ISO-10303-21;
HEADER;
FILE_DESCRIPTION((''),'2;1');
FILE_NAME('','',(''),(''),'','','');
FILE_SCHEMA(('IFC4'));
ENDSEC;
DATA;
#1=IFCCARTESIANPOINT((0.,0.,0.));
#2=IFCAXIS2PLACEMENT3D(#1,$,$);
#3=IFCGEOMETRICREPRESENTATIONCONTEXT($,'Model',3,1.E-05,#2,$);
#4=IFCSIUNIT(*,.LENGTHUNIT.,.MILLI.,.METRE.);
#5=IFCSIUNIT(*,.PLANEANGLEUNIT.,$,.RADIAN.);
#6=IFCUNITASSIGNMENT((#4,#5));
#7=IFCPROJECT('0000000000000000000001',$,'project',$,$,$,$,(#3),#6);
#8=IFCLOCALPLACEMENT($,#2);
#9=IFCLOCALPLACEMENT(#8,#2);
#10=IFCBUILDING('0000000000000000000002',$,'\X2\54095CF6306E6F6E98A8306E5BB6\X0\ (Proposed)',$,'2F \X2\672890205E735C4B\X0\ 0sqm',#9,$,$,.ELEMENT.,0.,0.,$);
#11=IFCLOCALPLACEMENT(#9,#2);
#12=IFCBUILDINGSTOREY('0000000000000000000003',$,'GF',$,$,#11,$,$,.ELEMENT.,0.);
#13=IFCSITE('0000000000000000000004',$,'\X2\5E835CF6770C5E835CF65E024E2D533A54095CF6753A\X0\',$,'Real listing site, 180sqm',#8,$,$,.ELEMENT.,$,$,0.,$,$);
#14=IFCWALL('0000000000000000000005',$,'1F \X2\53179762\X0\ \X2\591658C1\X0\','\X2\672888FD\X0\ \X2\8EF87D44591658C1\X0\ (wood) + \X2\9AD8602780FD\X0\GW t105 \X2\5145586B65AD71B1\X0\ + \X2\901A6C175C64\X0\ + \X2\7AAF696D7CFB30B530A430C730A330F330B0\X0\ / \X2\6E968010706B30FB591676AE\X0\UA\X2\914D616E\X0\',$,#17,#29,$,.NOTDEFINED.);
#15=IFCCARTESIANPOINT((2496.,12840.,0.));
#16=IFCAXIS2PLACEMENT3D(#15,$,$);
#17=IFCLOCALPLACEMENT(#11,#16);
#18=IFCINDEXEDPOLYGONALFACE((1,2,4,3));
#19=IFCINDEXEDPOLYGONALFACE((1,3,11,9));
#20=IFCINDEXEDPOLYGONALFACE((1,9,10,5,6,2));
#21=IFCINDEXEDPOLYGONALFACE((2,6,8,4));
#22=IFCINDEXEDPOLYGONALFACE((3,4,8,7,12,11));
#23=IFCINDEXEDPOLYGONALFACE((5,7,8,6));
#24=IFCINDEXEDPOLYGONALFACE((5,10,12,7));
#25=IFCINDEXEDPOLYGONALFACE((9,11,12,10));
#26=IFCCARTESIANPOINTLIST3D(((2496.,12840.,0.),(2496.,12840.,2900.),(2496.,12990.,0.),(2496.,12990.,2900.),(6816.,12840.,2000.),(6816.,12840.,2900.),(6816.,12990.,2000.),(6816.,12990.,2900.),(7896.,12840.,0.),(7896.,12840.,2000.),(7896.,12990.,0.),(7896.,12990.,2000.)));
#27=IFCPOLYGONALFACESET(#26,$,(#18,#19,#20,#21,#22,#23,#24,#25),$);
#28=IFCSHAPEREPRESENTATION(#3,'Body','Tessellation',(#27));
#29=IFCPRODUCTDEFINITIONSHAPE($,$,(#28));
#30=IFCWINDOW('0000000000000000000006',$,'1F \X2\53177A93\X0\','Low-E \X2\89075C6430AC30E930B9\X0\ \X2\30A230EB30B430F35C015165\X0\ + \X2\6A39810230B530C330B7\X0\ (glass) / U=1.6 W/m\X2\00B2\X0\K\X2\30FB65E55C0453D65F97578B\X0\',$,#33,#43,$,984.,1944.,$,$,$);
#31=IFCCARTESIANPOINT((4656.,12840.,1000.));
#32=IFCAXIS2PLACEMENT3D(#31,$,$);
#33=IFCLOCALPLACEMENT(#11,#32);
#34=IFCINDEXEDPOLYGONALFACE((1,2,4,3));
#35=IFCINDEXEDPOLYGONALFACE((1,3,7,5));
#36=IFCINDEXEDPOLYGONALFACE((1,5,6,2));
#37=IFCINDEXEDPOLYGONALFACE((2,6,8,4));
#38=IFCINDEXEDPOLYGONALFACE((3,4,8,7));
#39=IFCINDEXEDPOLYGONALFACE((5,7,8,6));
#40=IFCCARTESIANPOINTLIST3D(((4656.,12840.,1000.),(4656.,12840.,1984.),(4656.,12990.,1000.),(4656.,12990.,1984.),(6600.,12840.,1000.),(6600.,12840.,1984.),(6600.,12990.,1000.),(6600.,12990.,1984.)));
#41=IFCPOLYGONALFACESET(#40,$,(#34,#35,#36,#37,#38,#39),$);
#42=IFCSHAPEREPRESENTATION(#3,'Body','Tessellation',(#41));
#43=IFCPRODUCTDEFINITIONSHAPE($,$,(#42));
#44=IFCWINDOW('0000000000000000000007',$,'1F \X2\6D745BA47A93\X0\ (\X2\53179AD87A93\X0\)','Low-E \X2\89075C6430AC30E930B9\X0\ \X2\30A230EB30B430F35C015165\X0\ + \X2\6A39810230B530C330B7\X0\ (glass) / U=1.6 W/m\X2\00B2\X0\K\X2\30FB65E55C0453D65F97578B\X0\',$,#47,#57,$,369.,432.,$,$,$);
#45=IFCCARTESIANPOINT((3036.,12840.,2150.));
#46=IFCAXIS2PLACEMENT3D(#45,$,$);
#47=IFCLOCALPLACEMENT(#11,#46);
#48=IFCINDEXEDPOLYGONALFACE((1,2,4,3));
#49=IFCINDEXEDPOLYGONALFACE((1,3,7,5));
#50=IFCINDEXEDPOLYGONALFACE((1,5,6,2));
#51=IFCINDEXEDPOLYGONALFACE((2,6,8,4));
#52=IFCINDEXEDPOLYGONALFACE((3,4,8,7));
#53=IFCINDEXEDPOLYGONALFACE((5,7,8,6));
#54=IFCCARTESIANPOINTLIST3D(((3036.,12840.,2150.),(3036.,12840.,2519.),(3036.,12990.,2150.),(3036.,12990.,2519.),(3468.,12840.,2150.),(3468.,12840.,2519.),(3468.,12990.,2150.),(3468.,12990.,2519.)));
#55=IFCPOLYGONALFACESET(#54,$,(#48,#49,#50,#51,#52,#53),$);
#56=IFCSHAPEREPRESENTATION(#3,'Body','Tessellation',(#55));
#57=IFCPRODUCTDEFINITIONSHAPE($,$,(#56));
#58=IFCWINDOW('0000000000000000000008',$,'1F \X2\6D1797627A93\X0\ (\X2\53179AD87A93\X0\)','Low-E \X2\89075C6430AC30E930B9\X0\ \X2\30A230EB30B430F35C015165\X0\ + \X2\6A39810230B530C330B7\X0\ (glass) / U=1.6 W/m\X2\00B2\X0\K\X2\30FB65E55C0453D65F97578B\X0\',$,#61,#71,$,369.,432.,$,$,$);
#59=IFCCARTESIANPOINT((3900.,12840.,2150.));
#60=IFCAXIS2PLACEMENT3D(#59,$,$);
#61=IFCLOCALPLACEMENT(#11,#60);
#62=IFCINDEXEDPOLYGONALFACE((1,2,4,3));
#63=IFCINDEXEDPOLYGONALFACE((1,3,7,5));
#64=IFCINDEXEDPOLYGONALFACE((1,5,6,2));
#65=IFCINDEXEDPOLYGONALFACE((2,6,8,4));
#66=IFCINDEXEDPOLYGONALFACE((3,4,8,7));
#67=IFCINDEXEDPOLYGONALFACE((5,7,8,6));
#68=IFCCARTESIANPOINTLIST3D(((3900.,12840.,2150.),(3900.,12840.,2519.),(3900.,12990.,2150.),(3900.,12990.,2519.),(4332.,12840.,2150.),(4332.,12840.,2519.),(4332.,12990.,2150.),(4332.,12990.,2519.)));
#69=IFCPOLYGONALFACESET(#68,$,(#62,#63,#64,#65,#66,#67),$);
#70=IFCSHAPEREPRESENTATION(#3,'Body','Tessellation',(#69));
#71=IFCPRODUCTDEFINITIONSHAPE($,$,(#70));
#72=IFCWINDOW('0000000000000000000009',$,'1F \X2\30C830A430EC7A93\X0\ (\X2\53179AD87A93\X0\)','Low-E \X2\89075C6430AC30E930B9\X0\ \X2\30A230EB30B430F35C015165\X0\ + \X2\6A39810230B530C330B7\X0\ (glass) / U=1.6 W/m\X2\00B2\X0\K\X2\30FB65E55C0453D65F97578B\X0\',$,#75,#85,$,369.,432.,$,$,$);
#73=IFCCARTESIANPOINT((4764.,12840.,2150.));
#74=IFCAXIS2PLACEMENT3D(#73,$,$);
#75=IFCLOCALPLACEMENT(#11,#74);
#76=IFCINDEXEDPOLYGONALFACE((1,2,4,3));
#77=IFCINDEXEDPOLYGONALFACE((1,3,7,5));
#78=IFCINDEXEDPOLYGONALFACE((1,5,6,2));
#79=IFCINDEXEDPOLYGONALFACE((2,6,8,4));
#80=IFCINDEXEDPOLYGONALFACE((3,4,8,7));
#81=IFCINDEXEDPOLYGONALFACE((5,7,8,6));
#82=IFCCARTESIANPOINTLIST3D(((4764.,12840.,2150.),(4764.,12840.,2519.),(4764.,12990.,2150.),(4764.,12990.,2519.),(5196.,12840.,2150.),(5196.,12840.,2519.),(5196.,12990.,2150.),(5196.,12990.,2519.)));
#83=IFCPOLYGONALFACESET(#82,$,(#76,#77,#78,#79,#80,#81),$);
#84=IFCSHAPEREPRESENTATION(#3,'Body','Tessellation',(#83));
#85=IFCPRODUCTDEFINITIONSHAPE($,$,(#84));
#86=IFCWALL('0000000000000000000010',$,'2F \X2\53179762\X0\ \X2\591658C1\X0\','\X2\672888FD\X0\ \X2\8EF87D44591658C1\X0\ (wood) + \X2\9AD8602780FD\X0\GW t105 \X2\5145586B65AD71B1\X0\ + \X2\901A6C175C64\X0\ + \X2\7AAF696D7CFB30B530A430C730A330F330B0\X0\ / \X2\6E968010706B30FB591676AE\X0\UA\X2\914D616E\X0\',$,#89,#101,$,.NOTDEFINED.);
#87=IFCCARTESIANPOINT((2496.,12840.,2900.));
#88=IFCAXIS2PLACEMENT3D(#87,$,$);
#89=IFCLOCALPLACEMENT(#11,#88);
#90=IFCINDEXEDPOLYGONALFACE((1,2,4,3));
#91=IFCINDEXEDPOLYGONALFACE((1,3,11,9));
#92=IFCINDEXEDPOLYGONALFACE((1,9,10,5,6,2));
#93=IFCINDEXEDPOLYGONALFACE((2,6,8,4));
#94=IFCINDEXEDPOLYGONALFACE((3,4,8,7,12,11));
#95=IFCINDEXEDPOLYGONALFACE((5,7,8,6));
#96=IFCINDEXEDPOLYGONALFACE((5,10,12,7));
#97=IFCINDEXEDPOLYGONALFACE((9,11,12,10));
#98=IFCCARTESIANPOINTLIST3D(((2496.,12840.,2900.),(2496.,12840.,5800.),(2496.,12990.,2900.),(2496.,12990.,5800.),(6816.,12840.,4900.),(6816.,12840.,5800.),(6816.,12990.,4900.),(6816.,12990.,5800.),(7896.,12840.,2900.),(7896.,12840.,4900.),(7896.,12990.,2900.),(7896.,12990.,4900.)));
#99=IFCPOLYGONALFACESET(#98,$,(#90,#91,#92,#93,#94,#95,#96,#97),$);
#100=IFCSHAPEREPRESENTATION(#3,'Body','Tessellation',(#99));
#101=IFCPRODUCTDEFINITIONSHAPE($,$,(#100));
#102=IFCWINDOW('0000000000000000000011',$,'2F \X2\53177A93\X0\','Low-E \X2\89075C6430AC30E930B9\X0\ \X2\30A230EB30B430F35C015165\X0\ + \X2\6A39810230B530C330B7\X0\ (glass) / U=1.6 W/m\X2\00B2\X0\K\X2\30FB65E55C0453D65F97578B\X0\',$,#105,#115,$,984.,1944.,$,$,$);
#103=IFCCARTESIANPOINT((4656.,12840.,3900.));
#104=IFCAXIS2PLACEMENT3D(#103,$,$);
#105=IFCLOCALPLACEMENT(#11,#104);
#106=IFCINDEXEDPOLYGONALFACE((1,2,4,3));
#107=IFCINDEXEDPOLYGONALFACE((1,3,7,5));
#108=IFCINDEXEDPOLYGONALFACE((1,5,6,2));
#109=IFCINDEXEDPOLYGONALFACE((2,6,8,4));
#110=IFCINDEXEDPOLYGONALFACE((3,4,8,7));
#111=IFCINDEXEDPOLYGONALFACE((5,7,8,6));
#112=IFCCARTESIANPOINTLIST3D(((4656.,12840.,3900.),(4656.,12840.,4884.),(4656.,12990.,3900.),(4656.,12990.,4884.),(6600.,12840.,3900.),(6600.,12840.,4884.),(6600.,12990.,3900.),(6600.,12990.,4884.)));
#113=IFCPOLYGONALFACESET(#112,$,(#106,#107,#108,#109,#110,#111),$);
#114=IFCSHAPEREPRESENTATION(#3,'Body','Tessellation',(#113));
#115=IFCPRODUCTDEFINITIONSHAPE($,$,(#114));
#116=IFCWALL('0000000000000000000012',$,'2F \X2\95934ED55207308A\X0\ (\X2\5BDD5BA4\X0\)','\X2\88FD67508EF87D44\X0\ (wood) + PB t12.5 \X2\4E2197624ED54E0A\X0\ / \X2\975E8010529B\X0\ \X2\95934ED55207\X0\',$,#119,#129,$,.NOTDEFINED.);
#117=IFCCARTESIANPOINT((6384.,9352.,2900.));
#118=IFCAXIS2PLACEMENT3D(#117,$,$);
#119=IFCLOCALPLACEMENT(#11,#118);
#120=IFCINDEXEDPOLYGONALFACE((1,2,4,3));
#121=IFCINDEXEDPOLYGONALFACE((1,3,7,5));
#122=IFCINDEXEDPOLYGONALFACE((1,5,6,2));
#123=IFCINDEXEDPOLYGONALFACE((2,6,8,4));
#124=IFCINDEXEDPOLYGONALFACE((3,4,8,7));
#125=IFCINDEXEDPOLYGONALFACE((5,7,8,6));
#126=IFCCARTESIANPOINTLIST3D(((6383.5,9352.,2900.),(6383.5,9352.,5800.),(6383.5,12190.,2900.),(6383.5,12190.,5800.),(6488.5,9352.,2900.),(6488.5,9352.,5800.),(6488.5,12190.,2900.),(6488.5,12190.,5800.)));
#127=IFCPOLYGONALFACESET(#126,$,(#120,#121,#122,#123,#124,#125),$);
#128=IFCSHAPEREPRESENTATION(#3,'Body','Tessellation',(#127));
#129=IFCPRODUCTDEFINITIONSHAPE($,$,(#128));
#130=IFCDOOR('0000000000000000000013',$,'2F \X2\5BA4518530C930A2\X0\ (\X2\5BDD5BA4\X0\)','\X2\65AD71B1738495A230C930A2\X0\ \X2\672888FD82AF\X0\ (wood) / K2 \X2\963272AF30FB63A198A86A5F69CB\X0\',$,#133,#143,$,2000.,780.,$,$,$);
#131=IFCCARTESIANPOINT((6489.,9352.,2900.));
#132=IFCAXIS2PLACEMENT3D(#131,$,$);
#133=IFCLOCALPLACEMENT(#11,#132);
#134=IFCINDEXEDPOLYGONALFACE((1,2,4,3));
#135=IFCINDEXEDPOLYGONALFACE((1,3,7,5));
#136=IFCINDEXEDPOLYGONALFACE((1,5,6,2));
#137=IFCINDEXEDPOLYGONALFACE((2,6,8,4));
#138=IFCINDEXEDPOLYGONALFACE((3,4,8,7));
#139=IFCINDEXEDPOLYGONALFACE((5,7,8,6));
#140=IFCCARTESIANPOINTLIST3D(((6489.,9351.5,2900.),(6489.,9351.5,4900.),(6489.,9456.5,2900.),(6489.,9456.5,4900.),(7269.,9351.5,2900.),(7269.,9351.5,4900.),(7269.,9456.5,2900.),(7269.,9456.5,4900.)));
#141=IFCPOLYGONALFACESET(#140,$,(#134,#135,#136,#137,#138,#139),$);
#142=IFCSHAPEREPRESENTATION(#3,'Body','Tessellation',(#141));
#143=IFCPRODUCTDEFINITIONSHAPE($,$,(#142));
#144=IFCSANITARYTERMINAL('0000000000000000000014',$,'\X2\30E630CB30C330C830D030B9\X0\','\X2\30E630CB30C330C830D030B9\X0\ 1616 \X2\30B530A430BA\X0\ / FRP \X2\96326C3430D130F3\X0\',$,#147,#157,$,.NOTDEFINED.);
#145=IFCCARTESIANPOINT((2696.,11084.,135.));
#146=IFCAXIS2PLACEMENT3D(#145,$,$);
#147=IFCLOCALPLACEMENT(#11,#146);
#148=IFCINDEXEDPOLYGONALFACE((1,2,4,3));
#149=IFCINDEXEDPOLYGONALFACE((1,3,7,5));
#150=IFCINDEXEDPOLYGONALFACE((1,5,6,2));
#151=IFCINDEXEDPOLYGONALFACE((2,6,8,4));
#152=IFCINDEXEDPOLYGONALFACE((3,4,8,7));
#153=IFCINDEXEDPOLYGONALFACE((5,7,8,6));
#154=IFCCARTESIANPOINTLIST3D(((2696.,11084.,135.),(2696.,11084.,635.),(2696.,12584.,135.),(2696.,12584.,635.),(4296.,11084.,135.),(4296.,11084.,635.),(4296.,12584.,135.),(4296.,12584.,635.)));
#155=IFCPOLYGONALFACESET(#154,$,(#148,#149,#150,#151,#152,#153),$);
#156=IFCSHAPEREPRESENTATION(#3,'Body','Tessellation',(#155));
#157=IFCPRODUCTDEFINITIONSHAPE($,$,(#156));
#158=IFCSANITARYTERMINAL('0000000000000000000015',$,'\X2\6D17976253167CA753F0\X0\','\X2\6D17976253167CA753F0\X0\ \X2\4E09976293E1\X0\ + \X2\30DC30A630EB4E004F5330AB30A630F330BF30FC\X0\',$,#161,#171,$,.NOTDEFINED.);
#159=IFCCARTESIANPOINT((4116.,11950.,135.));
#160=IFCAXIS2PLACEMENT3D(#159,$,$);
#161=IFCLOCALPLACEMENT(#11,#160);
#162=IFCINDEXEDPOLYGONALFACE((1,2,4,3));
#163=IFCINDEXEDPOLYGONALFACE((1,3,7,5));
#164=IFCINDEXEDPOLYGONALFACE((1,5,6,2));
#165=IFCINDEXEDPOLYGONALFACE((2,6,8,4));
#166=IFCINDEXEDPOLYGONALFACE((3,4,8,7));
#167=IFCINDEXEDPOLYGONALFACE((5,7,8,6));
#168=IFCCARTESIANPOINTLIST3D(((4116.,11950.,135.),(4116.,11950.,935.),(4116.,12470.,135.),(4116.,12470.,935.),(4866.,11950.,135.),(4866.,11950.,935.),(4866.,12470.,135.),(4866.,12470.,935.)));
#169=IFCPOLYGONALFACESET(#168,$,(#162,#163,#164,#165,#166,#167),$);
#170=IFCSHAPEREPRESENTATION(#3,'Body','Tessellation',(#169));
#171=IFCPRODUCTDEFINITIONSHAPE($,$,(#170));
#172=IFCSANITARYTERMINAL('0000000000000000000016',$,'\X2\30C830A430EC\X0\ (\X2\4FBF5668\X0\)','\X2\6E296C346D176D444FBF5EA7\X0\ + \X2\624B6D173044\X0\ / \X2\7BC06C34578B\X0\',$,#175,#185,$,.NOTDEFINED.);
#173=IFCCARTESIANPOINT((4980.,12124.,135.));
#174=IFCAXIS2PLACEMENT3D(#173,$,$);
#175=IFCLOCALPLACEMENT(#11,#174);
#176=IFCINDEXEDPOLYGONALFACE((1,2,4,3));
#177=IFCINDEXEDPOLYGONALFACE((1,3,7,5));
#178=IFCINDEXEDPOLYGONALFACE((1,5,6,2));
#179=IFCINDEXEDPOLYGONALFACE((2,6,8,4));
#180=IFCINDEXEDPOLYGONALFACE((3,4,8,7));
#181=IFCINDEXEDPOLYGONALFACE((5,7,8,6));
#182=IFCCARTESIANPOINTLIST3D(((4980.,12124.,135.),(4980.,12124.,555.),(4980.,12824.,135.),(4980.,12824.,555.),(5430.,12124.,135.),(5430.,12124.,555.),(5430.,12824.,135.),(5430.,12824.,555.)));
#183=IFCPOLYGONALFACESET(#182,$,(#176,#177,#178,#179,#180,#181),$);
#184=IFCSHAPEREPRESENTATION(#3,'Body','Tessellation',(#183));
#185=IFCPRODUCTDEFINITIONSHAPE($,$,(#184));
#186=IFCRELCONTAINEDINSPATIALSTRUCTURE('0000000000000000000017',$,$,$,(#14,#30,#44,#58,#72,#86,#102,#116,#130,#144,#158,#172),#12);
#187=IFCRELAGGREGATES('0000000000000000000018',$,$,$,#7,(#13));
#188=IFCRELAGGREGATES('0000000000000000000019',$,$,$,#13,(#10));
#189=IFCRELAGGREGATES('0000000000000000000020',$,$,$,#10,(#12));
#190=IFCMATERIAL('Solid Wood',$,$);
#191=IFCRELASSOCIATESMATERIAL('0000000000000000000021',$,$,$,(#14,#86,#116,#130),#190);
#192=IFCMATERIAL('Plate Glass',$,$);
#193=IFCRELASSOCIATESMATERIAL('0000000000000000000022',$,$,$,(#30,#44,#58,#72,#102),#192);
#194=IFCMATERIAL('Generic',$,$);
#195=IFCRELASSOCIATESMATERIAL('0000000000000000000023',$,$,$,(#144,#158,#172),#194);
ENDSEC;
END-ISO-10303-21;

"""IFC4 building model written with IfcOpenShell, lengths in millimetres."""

from ifc_helpers import new_model, si_unit, frame, frame_2d, origin, place, context, project, spatial, rectangle, extrude, material, element, fill, save


model = new_model("IFC4")

# Units and contexts
model_context = context("Model", 3, precision=1e-05, world=origin())
ifc_project = project(units=[si_unit("LENGTHUNIT", "METRE", prefix="MILLI"), si_unit("PLANEANGLEUNIT", "RADIAN")], contexts=[model_context])

# Site, building, storey
site_placement = place(None, origin())
site = spatial("IfcSite", under=ifc_project, at=site_placement, Name="広島県広島市中区吉島町", ObjectType="Real listing site, 180sqm", CompositionType="ELEMENT", RefElevation=0.0)
building_placement = place(site_placement, origin())
building = spatial("IfcBuilding", under=site, at=building_placement, Name="吉島の潮風の家 (Proposed)", ObjectType="2F 木造平屋 0sqm", CompositionType="ELEMENT", ElevationOfRefHeight=0.0, ElevationOfTerrain=0.0)
storey_placement = place(building_placement, origin())
storey = spatial("IfcBuildingStorey", under=building, at=storey_placement, Name="GF", CompositionType="ELEMENT", Elevation=0.0)

# Wall, openings, windows
ifc_material_1 = material(Name="Solid Wood")
wall_1_placement = place(storey_placement, frame((2496.0, 12840.0, 0.0)))
wall_1 = element("IfcWall", 1, at=wall_1_placement, inside=storey, material=ifc_material_1, Name="1F 北面 外壁", Description="木製 軸組外壁 (wood) + 高性能GW t105 充填断熱 + 通気層 + 窯業系サイディング / 準耐火・外皮UA配慮", PredefinedType="NOTDEFINED", context=model_context, shape_type="SweptSolid", body=[
    extrude(rectangle(XDim=5400.0, YDim=150.0, at=frame_2d((2700.0, 75.0))), frame((2496.0, 12840.0, 0.0)), (0.0, 0.0, 1.0), 2900.0),
])
opening_1_placement = place(storey_placement, frame((4656.0, 12840.0, 1000.0)))
opening_1 = element("IfcOpeningElement", 2, at=opening_1_placement, cuts=wall_1, PredefinedType="NOTDEFINED", context=model_context, shape_type="SweptSolid", body=[
    extrude(rectangle(XDim=1944.0, YDim=150.0, at=frame_2d((972.0, 75.0))), frame((4656.0, 12840.0, 1000.0)), (0.0, 0.0, 1.0), 984.0),
])
opening_2_placement = place(storey_placement, frame((3036.0, 12840.0, 2150.0)))
opening_2 = element("IfcOpeningElement", 3, at=opening_2_placement, cuts=wall_1, PredefinedType="NOTDEFINED", context=model_context, shape_type="SweptSolid", body=[
    extrude(rectangle(XDim=432.0, YDim=150.0, at=frame_2d((216.0, 75.0))), frame((3036.0, 12840.0, 2150.0)), (0.0, 0.0, 1.0), 369.0),
])
opening_3_placement = place(storey_placement, frame((3900.0, 12840.0, 2150.0)))
opening_3 = element("IfcOpeningElement", 4, at=opening_3_placement, cuts=wall_1, PredefinedType="NOTDEFINED", context=model_context, shape_type="SweptSolid", body=[
    extrude(rectangle(XDim=432.0, YDim=150.0, at=frame_2d((216.0, 75.0))), frame((3900.0, 12840.0, 2150.0)), (0.0, 0.0, 1.0), 369.0),
])
opening_4_placement = place(storey_placement, frame((4764.0, 12840.0, 2150.0)))
opening_4 = element("IfcOpeningElement", 5, at=opening_4_placement, cuts=wall_1, PredefinedType="NOTDEFINED", context=model_context, shape_type="SweptSolid", body=[
    extrude(rectangle(XDim=432.0, YDim=150.0, at=frame_2d((216.0, 75.0))), frame((4764.0, 12840.0, 2150.0)), (0.0, 0.0, 1.0), 369.0),
])
ifc_material_2 = material(Name="Plate Glass")
window_1_placement = place(storey_placement, frame((4656.0, 12840.0, 1000.0)))
window_1 = element("IfcWindow", 6, at=window_1_placement, inside=storey, material=ifc_material_2, Name="1F 北窓", Description="Low-E 複層ガラス アルゴン封入 + 樹脂サッシ (glass) / U=1.6 W/m²K・日射取得型", OverallHeight=984.0, OverallWidth=1944.0, context=model_context, shape_type="SweptSolid", body=[
    extrude(rectangle(XDim=1944.0, YDim=150.0, at=frame_2d((972.0, 75.0))), frame((4656.0, 12840.0, 1000.0)), (0.0, 0.0, 1.0), 984.0),
])
fill(opening_1, window_1)
window_2_placement = place(storey_placement, frame((3036.0, 12840.0, 2150.0)))
window_2 = element("IfcWindow", 7, at=window_2_placement, inside=storey, material=ifc_material_2, Name="1F 浴室窓 (北高窓)", Description="Low-E 複層ガラス アルゴン封入 + 樹脂サッシ (glass) / U=1.6 W/m²K・日射取得型", OverallHeight=369.0, OverallWidth=432.0, context=model_context, shape_type="SweptSolid", body=[
    extrude(rectangle(XDim=432.0, YDim=150.0, at=frame_2d((216.0, 75.0))), frame((3036.0, 12840.0, 2150.0)), (0.0, 0.0, 1.0), 369.0),
])
fill(opening_2, window_2)
window_3_placement = place(storey_placement, frame((3900.0, 12840.0, 2150.0)))
window_3 = element("IfcWindow", 8, at=window_3_placement, inside=storey, material=ifc_material_2, Name="1F 洗面窓 (北高窓)", Description="Low-E 複層ガラス アルゴン封入 + 樹脂サッシ (glass) / U=1.6 W/m²K・日射取得型", OverallHeight=369.0, OverallWidth=432.0, context=model_context, shape_type="SweptSolid", body=[
    extrude(rectangle(XDim=432.0, YDim=150.0, at=frame_2d((216.0, 75.0))), frame((3900.0, 12840.0, 2150.0)), (0.0, 0.0, 1.0), 369.0),
])
fill(opening_3, window_3)
window_4_placement = place(storey_placement, frame((4764.0, 12840.0, 2150.0)))
window_4 = element("IfcWindow", 9, at=window_4_placement, inside=storey, material=ifc_material_2, Name="1F トイレ窓 (北高窓)", Description="Low-E 複層ガラス アルゴン封入 + 樹脂サッシ (glass) / U=1.6 W/m²K・日射取得型", OverallHeight=369.0, OverallWidth=432.0, context=model_context, shape_type="SweptSolid", body=[
    extrude(rectangle(XDim=432.0, YDim=150.0, at=frame_2d((216.0, 75.0))), frame((4764.0, 12840.0, 2150.0)), (0.0, 0.0, 1.0), 369.0),
])
fill(opening_4, window_4)

# Wall, opening, window
wall_2_placement = place(storey_placement, frame((2496.0, 12840.0, 2900.0)))
wall_2 = element("IfcWall", 10, at=wall_2_placement, inside=storey, material=ifc_material_1, Name="2F 北面 外壁", Description="木製 軸組外壁 (wood) + 高性能GW t105 充填断熱 + 通気層 + 窯業系サイディング / 準耐火・外皮UA配慮", PredefinedType="NOTDEFINED", context=model_context, shape_type="SweptSolid", body=[
    extrude(rectangle(XDim=5400.0, YDim=150.0, at=frame_2d((2700.0, 75.0))), frame((2496.0, 12840.0, 2900.0)), (0.0, 0.0, 1.0), 2900.0),
])
opening_5_placement = place(storey_placement, frame((4656.0, 12840.0, 3900.0)))
opening_5 = element("IfcOpeningElement", 11, at=opening_5_placement, cuts=wall_2, PredefinedType="NOTDEFINED", context=model_context, shape_type="SweptSolid", body=[
    extrude(rectangle(XDim=1944.0, YDim=150.0, at=frame_2d((972.0, 75.0))), frame((4656.0, 12840.0, 3900.0)), (0.0, 0.0, 1.0), 984.0),
])
window_5_placement = place(storey_placement, frame((4656.0, 12840.0, 3900.0)))
window_5 = element("IfcWindow", 12, at=window_5_placement, inside=storey, material=ifc_material_2, Name="2F 北窓", Description="Low-E 複層ガラス アルゴン封入 + 樹脂サッシ (glass) / U=1.6 W/m²K・日射取得型", OverallHeight=984.0, OverallWidth=1944.0, context=model_context, shape_type="SweptSolid", body=[
    extrude(rectangle(XDim=1944.0, YDim=150.0, at=frame_2d((972.0, 75.0))), frame((4656.0, 12840.0, 3900.0)), (0.0, 0.0, 1.0), 984.0),
])
fill(opening_5, window_5)

# Wall
wall_3_placement = place(storey_placement, frame((6384.0, 9352.0, 2900.0)))
element("IfcWall", 13, at=wall_3_placement, inside=storey, material=ifc_material_1, Name="2F 間仕切り (寝室)", Description="製材軸組 (wood) + PB t12.5 両面仕上 / 非耐力 間仕切", PredefinedType="NOTDEFINED", context=model_context, shape_type="SweptSolid", body=[
    extrude(rectangle(XDim=105.0, YDim=2838.0, at=frame_2d((52.0, 1419.0))), frame((6384.0, 9352.0, 2900.0)), (0.0, 0.0, 1.0), 2900.0),
])

# Door
door_1_placement = place(storey_placement, frame((6489.0, 9352.0, 2900.0)))
element("IfcDoor", 14, at=door_1_placement, inside=storey, material=ifc_material_1, Name="2F 室内ドア (寝室)", Description="断熱玄関ドア 木製芯 (wood) / K2 防犯・採風機構", OverallHeight=2000.0, OverallWidth=780.0, context=model_context, shape_type="SweptSolid", body=[
    extrude(rectangle(XDim=780.0, YDim=105.0, at=frame_2d((390.0, 52.0))), frame((6489.0, 9352.0, 2900.0)), (0.0, 0.0, 1.0), 2000.0),
])

# Sanitary terminals
ifc_material_3 = material(Name="Generic")
sanitary_terminal_1_placement = place(storey_placement, frame((2696.0, 11084.0, 135.0)))
element("IfcSanitaryTerminal", 15, at=sanitary_terminal_1_placement, inside=storey, material=ifc_material_3, Name="ユニットバス", Description="ユニットバス 1616 サイズ / FRP 防水パン", PredefinedType="NOTDEFINED", context=model_context, shape_type="SweptSolid", body=[
    extrude(rectangle(XDim=1600.0, YDim=1500.0, at=frame_2d((800.0, 750.0))), frame((2696.0, 11084.0, 135.0)), (0.0, 0.0, 1.0), 500.0),
])
sanitary_terminal_2_placement = place(storey_placement, frame((4116.0, 11950.0, 135.0)))
element("IfcSanitaryTerminal", 16, at=sanitary_terminal_2_placement, inside=storey, material=ifc_material_3, Name="洗面化粧台", Description="洗面化粧台 三面鏡 + ボウル一体カウンター", PredefinedType="NOTDEFINED", context=model_context, shape_type="SweptSolid", body=[
    extrude(rectangle(XDim=750.0, YDim=520.0, at=frame_2d((375.0, 260.0))), frame((4116.0, 11950.0, 135.0)), (0.0, 0.0, 1.0), 800.0),
])
sanitary_terminal_3_placement = place(storey_placement, frame((4980.0, 12124.0, 135.0)))
element("IfcSanitaryTerminal", 17, at=sanitary_terminal_3_placement, inside=storey, material=ifc_material_3, Name="トイレ (便器)", Description="温水洗浄便座 + 手洗い / 節水型", PredefinedType="NOTDEFINED", context=model_context, shape_type="SweptSolid", body=[
    extrude(rectangle(XDim=450.0, YDim=700.0, at=frame_2d((225.0, 350.0))), frame((4980.0, 12124.0, 135.0)), (0.0, 0.0, 1.0), 420.0),
])

save(model, "model.ifc")
